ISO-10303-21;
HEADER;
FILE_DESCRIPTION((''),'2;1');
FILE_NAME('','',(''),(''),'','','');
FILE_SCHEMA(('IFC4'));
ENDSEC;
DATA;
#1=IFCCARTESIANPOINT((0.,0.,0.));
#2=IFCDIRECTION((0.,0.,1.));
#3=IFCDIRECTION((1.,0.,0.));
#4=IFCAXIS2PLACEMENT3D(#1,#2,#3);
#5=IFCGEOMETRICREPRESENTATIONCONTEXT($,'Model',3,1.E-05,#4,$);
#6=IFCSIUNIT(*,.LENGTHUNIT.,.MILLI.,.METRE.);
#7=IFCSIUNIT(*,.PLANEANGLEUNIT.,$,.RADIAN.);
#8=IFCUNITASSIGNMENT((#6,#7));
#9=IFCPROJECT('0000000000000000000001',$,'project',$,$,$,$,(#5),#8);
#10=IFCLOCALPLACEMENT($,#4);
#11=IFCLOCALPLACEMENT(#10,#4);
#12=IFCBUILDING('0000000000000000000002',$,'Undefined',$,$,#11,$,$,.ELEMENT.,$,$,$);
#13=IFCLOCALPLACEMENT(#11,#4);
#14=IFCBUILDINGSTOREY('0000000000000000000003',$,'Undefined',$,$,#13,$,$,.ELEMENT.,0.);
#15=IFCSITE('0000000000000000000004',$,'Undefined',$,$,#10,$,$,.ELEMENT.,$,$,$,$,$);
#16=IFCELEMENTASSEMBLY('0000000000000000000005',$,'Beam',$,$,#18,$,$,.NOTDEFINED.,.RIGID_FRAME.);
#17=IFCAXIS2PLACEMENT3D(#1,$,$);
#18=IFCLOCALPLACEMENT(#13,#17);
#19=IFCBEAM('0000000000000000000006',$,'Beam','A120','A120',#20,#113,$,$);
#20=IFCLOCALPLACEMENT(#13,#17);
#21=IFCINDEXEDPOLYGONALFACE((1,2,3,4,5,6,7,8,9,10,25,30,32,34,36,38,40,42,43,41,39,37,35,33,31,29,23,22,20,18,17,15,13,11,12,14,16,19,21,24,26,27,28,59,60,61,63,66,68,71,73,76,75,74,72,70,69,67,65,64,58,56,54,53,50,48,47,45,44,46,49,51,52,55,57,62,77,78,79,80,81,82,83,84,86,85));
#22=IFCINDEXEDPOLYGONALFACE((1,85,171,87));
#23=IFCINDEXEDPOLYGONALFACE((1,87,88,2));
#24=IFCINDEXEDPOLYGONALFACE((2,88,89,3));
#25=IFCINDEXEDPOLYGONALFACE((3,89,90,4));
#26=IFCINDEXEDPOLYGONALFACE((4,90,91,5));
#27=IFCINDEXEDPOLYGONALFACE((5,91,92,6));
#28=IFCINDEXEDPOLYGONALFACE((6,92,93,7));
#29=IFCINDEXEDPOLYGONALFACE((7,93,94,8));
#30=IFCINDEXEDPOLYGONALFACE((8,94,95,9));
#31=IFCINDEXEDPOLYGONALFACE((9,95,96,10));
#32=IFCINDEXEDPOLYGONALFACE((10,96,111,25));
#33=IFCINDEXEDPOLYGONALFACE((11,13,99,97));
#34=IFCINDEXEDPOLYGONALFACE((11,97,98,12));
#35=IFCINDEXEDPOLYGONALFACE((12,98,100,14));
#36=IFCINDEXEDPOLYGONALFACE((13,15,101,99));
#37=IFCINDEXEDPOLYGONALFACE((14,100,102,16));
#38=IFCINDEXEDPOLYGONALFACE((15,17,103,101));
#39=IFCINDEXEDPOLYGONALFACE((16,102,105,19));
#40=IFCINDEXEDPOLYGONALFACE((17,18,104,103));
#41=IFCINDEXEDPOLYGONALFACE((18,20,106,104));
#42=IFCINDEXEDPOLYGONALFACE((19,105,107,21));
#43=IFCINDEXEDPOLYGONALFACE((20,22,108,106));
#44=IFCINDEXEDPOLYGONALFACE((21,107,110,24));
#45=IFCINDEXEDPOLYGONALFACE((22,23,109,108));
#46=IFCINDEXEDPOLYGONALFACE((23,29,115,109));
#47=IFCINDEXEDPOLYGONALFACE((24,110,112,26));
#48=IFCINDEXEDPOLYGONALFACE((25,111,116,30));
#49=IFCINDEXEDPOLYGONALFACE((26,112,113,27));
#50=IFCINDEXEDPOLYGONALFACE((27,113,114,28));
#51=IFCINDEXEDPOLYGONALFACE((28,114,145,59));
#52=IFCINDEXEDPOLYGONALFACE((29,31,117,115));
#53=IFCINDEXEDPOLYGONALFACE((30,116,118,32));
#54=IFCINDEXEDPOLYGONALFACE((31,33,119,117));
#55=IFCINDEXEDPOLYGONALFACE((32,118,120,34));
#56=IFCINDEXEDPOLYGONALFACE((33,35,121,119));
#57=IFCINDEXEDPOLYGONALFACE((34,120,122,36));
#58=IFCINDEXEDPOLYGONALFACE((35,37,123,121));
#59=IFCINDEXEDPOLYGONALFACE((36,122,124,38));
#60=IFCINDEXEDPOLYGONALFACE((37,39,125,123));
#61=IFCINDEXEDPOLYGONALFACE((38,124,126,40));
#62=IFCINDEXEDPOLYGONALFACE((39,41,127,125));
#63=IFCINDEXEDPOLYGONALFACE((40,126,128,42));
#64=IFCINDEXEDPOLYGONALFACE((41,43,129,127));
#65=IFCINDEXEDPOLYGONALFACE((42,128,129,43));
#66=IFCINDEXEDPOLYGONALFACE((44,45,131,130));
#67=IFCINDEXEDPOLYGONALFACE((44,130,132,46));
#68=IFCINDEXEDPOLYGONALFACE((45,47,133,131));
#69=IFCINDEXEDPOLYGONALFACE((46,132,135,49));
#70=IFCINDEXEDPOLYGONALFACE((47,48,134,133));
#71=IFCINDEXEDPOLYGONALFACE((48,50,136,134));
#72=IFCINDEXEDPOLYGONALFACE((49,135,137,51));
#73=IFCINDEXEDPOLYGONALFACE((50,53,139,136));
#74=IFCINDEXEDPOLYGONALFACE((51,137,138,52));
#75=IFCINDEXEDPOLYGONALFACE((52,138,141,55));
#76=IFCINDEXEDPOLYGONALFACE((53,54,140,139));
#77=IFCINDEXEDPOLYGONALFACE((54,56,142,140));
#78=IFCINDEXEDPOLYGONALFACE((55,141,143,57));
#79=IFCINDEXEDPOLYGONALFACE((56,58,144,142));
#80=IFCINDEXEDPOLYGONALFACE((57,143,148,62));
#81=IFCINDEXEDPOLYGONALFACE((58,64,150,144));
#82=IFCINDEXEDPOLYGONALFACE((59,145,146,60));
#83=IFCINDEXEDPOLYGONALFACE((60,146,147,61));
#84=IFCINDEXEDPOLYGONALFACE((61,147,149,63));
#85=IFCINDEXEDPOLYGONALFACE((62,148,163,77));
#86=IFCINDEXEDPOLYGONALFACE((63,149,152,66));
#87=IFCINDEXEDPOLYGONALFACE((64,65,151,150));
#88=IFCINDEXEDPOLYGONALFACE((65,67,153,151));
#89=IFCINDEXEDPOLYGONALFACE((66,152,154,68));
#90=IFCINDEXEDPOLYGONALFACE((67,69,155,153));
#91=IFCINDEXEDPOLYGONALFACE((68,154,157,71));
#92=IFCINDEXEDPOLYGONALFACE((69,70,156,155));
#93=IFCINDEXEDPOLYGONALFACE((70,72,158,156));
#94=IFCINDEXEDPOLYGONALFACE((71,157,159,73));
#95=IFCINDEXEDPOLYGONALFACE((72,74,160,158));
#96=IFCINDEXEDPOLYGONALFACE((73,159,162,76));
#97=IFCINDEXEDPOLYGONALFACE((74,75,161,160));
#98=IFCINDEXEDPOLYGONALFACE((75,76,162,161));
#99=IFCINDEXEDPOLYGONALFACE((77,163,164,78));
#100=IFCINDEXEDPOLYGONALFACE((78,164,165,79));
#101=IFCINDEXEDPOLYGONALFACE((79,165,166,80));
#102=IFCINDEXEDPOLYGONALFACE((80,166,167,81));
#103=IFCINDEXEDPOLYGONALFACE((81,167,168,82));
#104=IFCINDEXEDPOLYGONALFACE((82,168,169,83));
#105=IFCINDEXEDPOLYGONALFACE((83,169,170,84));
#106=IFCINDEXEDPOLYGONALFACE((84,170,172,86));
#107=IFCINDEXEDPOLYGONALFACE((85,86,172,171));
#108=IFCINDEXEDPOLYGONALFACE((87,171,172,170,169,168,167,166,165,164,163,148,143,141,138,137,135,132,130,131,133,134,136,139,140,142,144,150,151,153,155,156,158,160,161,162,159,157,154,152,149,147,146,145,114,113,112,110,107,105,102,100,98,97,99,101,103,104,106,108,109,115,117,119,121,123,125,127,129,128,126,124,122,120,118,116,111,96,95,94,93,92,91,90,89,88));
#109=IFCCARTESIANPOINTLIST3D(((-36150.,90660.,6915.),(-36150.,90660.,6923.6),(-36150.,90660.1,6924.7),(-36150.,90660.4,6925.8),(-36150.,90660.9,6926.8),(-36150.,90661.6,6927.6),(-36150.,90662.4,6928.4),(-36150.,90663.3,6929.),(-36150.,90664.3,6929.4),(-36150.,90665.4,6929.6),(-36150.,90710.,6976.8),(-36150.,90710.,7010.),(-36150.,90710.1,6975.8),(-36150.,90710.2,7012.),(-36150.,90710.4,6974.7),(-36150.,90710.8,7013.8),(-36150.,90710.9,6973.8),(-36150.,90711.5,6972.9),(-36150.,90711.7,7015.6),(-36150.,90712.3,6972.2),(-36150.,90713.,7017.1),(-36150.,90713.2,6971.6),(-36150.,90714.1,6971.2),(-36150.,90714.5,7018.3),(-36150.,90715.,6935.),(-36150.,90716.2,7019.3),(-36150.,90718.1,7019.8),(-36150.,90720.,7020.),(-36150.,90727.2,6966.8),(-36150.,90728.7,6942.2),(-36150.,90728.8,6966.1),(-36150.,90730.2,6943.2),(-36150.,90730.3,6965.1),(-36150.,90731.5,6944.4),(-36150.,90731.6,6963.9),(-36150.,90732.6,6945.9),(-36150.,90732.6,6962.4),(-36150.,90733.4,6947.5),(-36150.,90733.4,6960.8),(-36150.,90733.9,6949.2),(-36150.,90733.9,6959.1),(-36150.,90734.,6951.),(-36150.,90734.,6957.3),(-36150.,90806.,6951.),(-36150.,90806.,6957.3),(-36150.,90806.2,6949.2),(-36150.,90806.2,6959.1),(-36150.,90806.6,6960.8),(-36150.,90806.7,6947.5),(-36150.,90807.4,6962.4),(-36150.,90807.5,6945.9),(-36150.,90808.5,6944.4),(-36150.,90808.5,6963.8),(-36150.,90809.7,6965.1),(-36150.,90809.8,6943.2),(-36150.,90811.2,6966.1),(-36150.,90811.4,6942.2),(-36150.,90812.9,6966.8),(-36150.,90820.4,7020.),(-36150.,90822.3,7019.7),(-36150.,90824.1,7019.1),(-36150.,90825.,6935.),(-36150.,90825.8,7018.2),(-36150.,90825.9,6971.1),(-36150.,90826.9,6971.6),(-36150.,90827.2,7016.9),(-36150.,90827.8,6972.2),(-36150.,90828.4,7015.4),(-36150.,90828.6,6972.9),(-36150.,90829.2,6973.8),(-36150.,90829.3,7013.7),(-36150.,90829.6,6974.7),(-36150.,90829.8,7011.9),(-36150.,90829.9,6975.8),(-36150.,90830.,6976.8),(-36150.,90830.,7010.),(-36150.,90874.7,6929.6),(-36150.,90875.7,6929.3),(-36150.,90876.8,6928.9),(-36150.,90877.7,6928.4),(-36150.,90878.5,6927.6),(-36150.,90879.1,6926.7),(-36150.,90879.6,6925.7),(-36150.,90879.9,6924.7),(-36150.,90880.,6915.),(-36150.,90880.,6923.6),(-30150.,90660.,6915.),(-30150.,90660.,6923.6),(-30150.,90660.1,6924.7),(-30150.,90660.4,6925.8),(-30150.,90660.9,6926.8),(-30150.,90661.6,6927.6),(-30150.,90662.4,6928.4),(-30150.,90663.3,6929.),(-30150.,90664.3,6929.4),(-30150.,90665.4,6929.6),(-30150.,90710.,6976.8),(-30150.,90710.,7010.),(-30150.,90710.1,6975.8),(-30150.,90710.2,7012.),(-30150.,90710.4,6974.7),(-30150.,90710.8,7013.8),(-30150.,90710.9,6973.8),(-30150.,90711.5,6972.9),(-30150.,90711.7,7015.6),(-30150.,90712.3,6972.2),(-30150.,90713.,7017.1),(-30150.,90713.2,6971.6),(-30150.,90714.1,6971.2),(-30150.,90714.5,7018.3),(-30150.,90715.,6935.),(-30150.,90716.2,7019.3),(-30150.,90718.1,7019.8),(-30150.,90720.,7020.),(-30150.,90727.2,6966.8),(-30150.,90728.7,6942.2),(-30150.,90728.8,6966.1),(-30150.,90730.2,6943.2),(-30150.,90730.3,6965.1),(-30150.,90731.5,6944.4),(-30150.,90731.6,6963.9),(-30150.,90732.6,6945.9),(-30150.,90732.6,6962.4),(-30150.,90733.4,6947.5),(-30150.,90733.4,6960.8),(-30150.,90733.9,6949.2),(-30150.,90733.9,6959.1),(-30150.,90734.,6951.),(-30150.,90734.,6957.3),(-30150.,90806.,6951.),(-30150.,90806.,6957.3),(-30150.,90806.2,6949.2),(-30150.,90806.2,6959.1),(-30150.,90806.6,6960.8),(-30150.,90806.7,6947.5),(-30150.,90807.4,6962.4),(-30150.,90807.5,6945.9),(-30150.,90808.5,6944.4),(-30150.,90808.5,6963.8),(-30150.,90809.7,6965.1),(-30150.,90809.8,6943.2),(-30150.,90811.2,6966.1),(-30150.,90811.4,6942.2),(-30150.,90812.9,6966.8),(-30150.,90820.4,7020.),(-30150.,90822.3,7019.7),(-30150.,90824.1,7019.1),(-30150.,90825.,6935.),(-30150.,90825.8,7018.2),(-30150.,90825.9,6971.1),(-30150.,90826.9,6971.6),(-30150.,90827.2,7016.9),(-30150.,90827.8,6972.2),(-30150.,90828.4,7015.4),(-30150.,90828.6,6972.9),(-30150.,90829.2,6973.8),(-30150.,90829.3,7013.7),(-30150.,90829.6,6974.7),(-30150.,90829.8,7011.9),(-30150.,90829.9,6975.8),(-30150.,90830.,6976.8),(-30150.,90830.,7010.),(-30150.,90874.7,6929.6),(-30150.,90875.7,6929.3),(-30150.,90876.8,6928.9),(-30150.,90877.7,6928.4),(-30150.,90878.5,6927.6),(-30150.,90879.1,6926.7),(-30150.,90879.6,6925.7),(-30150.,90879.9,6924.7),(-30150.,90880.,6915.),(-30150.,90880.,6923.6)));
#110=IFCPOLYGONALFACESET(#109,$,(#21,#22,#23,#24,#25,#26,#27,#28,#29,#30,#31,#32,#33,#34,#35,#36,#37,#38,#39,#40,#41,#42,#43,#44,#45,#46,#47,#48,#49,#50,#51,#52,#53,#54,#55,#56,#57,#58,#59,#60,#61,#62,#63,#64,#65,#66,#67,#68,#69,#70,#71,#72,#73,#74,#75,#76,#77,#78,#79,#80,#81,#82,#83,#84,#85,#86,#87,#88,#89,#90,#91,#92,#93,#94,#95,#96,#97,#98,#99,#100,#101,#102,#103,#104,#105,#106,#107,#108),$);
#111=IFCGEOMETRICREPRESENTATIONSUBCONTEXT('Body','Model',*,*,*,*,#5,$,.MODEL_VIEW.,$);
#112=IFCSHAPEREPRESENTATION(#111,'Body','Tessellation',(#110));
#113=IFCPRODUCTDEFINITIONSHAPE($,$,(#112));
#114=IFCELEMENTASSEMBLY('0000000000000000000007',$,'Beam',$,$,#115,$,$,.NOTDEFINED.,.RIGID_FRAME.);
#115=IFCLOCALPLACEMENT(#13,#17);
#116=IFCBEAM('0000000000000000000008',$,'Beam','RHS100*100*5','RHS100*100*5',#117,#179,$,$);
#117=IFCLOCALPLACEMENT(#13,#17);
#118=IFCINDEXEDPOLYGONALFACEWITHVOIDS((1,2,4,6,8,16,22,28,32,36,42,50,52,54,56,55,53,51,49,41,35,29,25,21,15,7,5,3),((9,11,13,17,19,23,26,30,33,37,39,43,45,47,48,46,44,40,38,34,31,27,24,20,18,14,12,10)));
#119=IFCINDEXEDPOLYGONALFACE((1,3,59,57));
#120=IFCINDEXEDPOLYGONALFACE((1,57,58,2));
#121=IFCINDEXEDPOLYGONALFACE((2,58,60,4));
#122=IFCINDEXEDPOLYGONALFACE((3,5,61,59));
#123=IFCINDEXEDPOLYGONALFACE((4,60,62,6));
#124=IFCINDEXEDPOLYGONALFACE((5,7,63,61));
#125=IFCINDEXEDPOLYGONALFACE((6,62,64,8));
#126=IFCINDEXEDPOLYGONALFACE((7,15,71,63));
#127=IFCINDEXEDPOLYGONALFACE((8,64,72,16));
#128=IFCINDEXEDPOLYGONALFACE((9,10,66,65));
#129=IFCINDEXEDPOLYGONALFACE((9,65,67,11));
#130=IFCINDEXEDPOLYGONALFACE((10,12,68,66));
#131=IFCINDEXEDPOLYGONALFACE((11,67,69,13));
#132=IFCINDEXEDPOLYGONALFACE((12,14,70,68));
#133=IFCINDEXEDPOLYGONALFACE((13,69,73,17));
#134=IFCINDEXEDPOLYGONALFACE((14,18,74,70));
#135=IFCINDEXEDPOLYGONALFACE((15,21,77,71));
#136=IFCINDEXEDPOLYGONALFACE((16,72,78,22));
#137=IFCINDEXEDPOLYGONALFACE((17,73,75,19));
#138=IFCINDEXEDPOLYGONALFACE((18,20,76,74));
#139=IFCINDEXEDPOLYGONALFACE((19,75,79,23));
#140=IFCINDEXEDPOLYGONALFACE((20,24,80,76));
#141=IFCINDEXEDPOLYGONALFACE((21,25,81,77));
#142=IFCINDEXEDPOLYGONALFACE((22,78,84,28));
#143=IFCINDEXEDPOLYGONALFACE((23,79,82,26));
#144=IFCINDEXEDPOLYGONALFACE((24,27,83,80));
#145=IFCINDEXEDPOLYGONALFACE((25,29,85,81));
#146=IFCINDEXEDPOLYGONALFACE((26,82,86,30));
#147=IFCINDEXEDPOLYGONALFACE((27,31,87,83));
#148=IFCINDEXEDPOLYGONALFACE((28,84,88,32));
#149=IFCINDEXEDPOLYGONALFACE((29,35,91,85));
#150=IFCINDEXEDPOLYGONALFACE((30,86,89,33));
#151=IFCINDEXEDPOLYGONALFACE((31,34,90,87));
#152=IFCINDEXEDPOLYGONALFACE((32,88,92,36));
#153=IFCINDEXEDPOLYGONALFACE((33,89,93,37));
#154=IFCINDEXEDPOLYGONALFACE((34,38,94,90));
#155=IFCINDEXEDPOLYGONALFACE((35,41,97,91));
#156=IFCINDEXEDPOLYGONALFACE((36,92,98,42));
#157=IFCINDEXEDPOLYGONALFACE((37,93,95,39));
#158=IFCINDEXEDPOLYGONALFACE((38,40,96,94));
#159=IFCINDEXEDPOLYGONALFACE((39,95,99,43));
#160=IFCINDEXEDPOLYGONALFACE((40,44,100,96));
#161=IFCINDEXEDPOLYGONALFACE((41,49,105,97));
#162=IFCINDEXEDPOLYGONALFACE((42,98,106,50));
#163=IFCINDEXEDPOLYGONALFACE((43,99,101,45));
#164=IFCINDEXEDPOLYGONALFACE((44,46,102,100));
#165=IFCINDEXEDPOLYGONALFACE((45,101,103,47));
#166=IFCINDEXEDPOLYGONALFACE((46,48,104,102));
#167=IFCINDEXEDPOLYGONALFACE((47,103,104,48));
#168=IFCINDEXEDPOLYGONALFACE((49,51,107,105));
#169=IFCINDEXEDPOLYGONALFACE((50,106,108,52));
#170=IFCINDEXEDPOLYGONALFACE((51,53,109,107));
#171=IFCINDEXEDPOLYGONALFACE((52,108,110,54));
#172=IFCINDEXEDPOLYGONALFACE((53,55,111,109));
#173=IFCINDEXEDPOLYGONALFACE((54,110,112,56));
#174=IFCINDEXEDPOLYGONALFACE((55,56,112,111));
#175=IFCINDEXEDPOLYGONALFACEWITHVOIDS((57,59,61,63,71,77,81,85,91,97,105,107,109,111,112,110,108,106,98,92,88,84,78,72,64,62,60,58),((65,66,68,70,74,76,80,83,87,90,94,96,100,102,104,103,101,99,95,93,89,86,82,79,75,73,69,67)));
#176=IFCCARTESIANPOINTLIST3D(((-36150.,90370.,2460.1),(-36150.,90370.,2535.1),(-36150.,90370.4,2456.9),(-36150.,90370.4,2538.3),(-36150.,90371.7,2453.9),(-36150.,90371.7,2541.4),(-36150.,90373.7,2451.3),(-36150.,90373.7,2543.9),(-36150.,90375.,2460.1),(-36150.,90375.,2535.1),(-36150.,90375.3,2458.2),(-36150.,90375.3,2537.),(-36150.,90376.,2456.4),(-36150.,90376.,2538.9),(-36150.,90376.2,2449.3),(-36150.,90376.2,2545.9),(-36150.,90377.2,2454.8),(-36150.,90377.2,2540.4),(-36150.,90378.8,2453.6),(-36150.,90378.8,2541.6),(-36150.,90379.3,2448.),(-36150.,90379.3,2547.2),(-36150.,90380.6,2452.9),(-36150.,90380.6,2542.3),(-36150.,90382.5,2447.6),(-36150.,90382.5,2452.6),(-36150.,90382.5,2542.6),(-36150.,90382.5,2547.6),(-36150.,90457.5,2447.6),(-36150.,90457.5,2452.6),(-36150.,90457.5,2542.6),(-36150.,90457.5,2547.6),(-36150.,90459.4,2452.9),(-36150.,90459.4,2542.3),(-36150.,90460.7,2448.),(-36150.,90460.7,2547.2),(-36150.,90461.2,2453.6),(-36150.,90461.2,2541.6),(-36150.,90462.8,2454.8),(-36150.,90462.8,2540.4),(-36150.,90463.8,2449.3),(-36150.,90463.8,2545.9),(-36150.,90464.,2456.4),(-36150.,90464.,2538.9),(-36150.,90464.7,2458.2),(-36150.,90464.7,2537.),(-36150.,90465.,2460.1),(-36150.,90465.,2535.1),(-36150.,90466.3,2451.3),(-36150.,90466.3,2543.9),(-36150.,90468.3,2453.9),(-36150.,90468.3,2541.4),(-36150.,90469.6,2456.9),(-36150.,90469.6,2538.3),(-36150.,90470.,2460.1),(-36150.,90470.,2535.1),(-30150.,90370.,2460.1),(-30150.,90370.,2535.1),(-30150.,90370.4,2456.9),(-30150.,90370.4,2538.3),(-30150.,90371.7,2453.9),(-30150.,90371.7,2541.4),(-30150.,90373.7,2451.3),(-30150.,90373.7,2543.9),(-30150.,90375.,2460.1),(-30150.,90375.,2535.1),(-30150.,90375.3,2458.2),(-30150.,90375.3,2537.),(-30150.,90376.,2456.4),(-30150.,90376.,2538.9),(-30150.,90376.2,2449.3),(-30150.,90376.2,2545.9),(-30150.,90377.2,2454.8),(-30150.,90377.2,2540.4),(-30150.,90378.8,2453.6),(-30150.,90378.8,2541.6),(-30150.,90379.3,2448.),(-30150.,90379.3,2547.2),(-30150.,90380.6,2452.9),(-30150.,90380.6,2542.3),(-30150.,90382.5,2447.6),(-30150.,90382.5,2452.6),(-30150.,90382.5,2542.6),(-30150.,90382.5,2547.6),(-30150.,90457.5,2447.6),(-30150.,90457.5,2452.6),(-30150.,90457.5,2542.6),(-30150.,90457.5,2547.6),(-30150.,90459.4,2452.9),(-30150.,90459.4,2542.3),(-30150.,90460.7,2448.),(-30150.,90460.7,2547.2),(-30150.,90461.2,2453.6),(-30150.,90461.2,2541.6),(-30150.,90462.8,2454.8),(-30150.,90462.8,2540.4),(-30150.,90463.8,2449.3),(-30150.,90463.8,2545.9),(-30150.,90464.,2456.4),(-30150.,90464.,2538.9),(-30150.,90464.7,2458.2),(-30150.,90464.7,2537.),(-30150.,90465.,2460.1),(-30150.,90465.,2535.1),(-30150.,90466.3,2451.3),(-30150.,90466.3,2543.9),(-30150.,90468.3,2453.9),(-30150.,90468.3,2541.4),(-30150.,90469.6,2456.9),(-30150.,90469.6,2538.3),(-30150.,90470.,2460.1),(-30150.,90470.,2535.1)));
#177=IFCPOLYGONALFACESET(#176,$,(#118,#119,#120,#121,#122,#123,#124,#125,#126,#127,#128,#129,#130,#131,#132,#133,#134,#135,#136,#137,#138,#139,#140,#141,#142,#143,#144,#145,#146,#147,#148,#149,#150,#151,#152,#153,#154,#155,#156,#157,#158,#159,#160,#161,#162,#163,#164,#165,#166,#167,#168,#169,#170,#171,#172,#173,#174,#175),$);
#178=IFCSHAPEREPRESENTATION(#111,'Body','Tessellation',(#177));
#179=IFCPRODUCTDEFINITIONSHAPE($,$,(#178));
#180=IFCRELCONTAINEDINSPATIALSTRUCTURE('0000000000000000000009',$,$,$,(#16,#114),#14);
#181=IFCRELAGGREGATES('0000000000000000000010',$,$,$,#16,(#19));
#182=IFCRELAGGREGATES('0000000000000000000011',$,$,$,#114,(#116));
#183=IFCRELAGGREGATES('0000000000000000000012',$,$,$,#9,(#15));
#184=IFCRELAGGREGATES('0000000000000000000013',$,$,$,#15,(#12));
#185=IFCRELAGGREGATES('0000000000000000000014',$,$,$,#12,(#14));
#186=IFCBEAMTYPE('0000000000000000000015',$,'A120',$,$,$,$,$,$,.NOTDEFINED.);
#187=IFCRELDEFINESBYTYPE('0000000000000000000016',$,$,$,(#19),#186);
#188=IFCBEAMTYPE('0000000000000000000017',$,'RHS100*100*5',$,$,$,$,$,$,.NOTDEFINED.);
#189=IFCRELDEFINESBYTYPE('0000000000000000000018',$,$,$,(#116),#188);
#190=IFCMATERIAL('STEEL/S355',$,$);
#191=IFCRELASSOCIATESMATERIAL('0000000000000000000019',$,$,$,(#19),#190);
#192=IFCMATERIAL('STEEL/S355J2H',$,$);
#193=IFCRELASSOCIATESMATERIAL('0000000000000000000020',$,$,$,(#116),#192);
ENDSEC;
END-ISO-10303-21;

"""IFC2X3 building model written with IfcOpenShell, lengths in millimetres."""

from ifc_helpers import new_model, si_unit, frame, origin_with_axes, origin_2d_with_axis, place, context, subcontext, project, spatial, polyline, hollow_rectangle, outline, extrude, material, type_object, element, aggregate, save


model = new_model("IFC2X3")

# Units and contexts
model_context = context("Model", 3, precision=1e-05, world=origin_with_axes())
body_context = subcontext(model_context, "Body", "Model", "MODEL_VIEW")
ifc_project = project(units=[si_unit("LENGTHUNIT", "METRE", prefix="MILLI"), si_unit("PLANEANGLEUNIT", "RADIAN")], contexts=[model_context])

# Site, building, storey
site_placement = place(None, origin_with_axes())
site = spatial("IfcSite", under=ifc_project, at=site_placement, Name="Undefined", CompositionType="ELEMENT")
building_placement = place(site_placement, origin_with_axes())
building = spatial("IfcBuilding", under=site, at=building_placement, Name="Undefined", CompositionType="ELEMENT")
storey_placement = place(building_placement, origin_with_axes())
storey = spatial("IfcBuildingStorey", under=building, at=storey_placement, Name="Undefined", CompositionType="ELEMENT", Elevation=0.0)

# Element assemblies, beams
ifc_material_1 = material(Name="STEEL/S355")
beam_type_1 = type_object("IfcBeamType", Name="A120", PredefinedType="NOTDEFINED")
assembly_1_placement = place(storey_placement, origin_with_axes())
assembly_1 = element("IfcElementAssembly", 1, at=assembly_1_placement, inside=storey, Name="Beam", AssemblyPlace="NOTDEFINED", PredefinedType="RIGID_FRAME")
beam_1_placement = place(assembly_1_placement, frame((-36150.0, 90770.0, 6967.5), z_axis=(0.0, 0.000118, 1.0), x_axis=(1.0, 0.0, 0.0)))
beam_1 = element("IfcBeam", 2, at=beam_1_placement, type_object=beam_type_1, material=ifc_material_1, Name="Beam", Description="A120", ObjectType="A120", context=body_context, shape_type="SweptSolid", body=[
    extrude(outline(polyline([(-110.0, -52.5), (-110.0, -43.9), (-109.9, -42.8), (-109.6, -41.8), (-109.1, -40.8), (-108.5, -39.9), (-107.7, -39.1), (-106.7, -38.6), (-105.7, -38.2), (-104.7, -37.9), (-55.0, -32.5), (-41.3, -25.3), (-39.8, -24.3), (-38.5, -23.1), (-37.4, -21.6), (-36.6, -20.0), (-36.2, -18.3), (-36.0, -16.5), (-36.0, -10.2), (-36.1, -8.4), (-36.6, -6.7), (-37.4, -5.1), (-38.4, -3.7), (-39.7, -2.4), (-41.2, -1.4), (-42.8, -0.7), (-55.9, 3.6), (-56.9, 4.1), (-57.8, 4.7), (-58.5, 5.4), (-59.2, 6.3), (-59.6, 7.2), (-59.9, 8.3), (-60.0, 9.3), (-60.0, 42.5), (-59.8, 44.4), (-59.3, 46.2), (-58.4, 47.9), (-57.2, 49.4), (-55.7, 50.7), (-54.1, 51.6), (-52.3, 52.2), (-50.4, 52.5), (50.0, 52.5), (51.9, 52.3), (53.8, 51.7), (55.5, 50.8), (57.1, 49.6), (58.3, 48.1), (59.2, 46.3), (59.8, 44.4), (60.0, 42.5), (60.0, 9.3), (59.9, 8.3), (59.6, 7.2), (59.2, 6.3), (58.5, 5.4), (57.8, 4.7), (56.9, 4.1), (55.9, 3.6), (42.8, -0.7), (41.2, -1.4), (39.7, -2.4), (38.4, -3.7), (37.4, -5.1), (36.6, -6.7), (36.1, -8.4), (36.0, -10.2), (36.0, -16.5), (36.2, -18.3), (36.6, -20.0), (37.4, -21.6), (38.5, -23.1), (39.8, -24.3), (41.3, -25.3), (55.0, -32.5), (104.7, -37.9), (105.7, -38.2), (106.7, -38.6), (107.7, -39.1), (108.5, -39.9), (109.1, -40.8), (109.6, -41.8), (109.9, -42.8), (110.0, -43.9), (110.0, -52.5), (-110.0, -52.5)])), frame((6000.0, 0.0, 0.0), z_axis=(-1.0, 0.0, 0.0), x_axis=(0.0, -1.0, 0.0)), (0.0, 0.0, 1.0), 6000.0),
])
aggregate(assembly_1, [beam_1])
assembly_2_placement = place(storey_placement, origin_with_axes())
assembly_2 = element("IfcElementAssembly", 3, at=assembly_2_placement, inside=storey, Name="Beam", AssemblyPlace="NOTDEFINED", PredefinedType="RIGID_FRAME")
ifc_material_2 = material(Name="STEEL/S355J2H")
beam_type_2 = type_object("IfcBeamType", Name="RHS100*100*5", PredefinedType="NOTDEFINED")
beam_2_placement = place(assembly_2_placement, frame((-30150.0, 90420.0, 2497.6), z_axis=(0.0, 0.0, 1.0), x_axis=(-1.0, 0.0, 0.0)))
beam_2 = element("IfcBeam", 4, at=beam_2_placement, type_object=beam_type_2, material=ifc_material_2, Name="Beam", Description="RHS100*100*5", ObjectType="RHS100*100*5", context=body_context, shape_type="SweptSolid", body=[
    extrude(hollow_rectangle(XDim=100.0, YDim=100.0, WallThickness=5.0, InnerFilletRadius=7.5, OuterFilletRadius=12.5, at=origin_2d_with_axis()), frame((6000.0, 0.0, 0.0), z_axis=(-1.0, 0.0, 0.0), x_axis=(0.0, -1.0, 0.0)), (0.0, 0.0, 1.0), 6000.0),
])
aggregate(assembly_2, [beam_2])

save(model, "model.ifc")
